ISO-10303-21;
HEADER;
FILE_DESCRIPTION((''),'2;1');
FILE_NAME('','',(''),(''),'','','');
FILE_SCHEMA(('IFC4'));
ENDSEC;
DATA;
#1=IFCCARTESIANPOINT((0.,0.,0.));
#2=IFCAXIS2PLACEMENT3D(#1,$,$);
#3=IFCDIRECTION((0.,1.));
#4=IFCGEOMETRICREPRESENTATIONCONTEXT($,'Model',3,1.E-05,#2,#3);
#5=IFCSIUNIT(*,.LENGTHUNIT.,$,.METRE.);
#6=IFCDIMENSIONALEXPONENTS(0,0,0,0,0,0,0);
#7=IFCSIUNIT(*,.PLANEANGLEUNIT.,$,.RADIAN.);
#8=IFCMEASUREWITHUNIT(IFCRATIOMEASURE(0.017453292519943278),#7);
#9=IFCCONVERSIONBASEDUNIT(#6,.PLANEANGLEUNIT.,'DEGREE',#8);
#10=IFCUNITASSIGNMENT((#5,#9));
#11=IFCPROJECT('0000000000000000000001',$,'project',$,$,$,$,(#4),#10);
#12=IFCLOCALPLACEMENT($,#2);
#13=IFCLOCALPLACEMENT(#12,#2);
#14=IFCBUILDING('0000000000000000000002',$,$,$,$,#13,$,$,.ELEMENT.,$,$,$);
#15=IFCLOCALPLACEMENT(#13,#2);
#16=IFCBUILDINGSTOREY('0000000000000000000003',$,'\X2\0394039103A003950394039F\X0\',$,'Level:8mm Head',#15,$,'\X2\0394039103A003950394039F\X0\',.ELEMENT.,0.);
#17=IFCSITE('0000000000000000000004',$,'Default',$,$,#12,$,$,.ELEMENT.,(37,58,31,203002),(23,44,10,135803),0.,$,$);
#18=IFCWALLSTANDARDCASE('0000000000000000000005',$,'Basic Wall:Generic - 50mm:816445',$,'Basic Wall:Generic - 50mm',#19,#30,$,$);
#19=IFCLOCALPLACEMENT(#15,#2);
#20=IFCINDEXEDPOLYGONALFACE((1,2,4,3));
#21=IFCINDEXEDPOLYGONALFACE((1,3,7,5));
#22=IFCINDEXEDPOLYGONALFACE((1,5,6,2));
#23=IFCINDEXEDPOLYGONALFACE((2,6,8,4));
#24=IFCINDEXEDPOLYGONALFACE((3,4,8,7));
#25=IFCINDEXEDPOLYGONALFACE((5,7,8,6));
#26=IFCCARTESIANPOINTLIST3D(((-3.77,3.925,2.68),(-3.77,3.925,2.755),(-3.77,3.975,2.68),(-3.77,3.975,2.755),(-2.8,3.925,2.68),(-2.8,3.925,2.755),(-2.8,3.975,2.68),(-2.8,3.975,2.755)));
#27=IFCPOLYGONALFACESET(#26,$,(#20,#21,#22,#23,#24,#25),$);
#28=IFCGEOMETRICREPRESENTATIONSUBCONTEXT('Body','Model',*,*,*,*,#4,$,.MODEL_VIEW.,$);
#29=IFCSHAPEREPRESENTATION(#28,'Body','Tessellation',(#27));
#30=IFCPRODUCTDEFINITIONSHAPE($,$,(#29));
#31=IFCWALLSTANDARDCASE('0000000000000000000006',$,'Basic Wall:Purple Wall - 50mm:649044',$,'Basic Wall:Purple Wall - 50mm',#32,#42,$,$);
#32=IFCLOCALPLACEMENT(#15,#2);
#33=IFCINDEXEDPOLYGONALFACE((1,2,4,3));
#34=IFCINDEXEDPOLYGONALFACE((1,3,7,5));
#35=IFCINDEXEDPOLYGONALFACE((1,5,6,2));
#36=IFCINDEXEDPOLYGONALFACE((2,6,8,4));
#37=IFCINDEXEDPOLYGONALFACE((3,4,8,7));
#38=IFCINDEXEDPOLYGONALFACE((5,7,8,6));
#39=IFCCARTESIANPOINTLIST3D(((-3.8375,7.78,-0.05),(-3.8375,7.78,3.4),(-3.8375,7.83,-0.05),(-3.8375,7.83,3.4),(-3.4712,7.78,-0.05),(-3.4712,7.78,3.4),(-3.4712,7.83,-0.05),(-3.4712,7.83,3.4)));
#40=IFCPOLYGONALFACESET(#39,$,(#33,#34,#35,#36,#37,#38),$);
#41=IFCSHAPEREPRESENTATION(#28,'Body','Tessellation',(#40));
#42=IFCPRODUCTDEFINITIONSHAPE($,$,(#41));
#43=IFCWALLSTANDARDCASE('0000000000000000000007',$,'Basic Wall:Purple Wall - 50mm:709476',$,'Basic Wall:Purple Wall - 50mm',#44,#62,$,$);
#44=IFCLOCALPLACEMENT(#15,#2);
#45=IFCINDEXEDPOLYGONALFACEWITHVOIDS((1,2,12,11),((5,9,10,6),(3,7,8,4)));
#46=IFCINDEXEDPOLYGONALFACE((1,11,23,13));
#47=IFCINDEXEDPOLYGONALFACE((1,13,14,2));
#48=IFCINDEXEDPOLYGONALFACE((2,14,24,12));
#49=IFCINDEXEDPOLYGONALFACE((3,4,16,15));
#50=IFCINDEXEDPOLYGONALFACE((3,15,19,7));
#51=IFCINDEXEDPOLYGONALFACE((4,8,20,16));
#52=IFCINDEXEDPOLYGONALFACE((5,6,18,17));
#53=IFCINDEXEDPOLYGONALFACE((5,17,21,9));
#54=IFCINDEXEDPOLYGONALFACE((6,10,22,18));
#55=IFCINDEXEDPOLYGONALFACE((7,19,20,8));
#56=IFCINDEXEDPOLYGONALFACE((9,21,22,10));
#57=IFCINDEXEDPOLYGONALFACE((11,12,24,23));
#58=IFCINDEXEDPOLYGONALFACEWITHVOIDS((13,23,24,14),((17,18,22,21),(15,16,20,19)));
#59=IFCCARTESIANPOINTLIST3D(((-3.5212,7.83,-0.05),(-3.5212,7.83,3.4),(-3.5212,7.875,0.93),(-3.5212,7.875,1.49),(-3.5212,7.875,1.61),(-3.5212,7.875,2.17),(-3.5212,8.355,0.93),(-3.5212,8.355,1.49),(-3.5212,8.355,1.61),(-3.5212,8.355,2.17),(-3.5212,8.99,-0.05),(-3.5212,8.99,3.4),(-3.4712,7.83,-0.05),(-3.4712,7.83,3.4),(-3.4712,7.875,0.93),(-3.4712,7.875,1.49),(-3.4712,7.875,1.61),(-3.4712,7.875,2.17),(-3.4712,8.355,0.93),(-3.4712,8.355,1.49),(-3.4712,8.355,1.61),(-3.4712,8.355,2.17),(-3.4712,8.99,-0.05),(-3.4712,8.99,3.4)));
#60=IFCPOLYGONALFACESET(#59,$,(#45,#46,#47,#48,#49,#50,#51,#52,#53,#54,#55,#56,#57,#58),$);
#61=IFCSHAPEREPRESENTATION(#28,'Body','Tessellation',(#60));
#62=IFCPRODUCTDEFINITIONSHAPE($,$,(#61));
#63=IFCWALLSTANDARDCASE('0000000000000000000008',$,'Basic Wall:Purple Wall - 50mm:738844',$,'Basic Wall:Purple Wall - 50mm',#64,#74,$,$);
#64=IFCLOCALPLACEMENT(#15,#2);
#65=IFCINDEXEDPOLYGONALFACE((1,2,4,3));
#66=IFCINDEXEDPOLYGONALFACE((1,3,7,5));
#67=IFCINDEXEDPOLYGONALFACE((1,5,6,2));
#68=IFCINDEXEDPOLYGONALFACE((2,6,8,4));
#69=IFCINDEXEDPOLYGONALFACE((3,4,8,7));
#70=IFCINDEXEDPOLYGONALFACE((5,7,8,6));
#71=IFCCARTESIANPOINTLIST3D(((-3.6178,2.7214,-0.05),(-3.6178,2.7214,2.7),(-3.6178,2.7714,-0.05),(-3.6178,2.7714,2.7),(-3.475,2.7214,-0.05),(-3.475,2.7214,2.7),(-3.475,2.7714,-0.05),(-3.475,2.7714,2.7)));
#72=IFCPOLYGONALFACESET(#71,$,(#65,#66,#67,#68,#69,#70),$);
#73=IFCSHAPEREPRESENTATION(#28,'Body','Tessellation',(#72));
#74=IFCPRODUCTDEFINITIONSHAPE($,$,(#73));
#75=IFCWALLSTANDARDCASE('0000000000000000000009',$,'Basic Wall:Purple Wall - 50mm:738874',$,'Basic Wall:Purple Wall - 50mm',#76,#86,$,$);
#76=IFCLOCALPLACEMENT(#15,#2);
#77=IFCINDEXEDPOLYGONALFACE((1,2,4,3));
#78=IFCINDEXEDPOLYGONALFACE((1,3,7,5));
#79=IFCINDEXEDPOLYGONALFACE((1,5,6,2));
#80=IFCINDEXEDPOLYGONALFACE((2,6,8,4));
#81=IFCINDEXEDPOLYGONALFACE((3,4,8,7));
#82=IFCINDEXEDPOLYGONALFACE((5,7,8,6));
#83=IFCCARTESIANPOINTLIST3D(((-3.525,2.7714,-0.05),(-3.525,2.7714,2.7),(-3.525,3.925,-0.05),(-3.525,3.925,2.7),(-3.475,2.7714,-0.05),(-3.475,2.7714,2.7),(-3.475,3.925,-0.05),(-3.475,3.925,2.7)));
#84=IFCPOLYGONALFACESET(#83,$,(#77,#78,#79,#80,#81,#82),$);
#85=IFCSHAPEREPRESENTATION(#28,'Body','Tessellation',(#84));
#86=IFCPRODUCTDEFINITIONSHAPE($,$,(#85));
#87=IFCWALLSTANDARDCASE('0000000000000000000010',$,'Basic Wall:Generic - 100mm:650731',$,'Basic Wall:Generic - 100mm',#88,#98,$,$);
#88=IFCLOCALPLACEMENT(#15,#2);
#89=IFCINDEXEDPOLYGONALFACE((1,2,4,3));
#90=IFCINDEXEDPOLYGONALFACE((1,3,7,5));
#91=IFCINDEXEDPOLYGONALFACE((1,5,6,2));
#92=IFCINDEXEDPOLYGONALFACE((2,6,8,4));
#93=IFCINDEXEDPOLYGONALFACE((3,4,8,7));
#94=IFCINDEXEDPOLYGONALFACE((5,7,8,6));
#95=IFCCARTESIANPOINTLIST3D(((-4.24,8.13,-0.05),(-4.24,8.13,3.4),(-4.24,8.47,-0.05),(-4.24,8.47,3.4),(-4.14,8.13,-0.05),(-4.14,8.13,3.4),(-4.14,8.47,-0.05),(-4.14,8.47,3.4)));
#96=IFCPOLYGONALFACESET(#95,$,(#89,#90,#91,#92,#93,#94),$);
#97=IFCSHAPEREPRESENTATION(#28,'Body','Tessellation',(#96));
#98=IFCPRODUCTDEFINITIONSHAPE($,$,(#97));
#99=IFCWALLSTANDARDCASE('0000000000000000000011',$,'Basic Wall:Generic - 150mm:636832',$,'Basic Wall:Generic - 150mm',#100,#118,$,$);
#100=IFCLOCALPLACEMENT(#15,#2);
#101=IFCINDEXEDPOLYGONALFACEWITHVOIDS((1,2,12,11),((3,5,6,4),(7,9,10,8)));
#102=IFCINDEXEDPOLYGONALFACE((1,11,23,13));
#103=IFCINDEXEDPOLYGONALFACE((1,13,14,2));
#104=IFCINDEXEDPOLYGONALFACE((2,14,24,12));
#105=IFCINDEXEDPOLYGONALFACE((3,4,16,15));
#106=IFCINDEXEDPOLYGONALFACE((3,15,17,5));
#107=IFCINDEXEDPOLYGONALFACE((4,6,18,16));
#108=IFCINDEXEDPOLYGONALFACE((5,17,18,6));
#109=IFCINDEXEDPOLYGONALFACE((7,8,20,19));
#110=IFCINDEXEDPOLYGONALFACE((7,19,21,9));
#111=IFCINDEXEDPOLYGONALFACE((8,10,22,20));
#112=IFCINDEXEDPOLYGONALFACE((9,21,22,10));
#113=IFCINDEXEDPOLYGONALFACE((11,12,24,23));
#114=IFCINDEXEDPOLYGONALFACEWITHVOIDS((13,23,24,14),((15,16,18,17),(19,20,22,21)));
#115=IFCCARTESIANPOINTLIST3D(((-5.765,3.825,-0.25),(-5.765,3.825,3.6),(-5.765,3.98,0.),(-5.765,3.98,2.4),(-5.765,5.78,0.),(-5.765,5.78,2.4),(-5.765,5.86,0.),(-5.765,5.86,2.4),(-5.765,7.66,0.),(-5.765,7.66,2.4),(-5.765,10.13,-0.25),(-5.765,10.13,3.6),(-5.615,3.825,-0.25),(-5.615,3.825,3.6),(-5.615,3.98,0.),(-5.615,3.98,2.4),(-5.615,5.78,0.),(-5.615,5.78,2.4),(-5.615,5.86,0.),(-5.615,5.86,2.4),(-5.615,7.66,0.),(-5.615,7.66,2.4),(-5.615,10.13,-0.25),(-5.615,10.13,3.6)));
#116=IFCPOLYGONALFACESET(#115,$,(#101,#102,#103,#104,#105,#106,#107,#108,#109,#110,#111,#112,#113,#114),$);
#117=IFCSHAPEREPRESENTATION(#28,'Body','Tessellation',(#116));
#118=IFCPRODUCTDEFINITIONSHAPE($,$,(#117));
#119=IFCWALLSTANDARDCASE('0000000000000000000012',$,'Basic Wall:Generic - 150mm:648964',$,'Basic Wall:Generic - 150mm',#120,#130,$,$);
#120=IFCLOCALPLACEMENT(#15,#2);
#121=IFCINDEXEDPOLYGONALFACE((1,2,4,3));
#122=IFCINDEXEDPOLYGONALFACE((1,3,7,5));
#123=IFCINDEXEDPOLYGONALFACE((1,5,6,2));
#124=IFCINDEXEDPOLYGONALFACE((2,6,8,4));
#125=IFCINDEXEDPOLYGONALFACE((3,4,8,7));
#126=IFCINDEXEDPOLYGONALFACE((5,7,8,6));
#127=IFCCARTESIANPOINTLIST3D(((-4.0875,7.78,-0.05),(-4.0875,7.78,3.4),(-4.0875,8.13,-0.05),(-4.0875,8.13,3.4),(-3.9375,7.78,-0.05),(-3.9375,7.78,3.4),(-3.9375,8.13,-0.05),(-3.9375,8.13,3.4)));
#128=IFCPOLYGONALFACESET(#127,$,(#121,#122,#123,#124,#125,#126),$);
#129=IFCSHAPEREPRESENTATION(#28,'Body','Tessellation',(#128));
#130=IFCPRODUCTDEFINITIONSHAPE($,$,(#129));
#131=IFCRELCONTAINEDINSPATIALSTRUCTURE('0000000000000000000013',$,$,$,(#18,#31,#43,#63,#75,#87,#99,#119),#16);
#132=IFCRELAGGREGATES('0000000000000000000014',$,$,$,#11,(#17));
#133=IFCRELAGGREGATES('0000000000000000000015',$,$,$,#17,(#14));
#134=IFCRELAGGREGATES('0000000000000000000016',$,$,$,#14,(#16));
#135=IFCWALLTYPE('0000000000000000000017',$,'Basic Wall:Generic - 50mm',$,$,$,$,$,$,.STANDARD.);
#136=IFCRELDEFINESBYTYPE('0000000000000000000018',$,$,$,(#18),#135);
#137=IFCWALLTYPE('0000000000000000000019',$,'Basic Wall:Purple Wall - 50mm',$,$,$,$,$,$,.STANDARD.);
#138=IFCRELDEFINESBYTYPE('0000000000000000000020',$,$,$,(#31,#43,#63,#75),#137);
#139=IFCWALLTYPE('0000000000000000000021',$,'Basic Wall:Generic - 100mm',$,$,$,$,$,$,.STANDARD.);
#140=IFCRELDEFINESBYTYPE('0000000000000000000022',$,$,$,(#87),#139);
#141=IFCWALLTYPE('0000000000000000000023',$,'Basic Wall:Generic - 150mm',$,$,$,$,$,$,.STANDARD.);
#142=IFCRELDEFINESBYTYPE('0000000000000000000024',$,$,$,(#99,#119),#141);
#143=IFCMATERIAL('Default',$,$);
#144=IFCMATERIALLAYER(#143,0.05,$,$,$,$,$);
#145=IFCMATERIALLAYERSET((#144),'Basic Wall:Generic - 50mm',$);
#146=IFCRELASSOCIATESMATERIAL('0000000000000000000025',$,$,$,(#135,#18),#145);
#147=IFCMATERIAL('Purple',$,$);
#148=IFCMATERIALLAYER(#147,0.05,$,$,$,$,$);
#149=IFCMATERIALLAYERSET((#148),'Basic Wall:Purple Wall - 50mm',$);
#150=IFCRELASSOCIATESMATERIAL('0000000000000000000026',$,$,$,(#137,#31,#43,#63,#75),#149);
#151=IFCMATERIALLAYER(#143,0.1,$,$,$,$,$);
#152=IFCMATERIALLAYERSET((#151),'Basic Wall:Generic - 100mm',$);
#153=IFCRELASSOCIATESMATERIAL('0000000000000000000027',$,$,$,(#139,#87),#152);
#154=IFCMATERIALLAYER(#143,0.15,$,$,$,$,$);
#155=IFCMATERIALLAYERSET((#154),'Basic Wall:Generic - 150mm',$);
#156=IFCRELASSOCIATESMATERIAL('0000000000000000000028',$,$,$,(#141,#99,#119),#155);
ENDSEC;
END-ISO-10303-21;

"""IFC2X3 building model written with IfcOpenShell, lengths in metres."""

from ifc_helpers import new_model, entity, si_unit, converted_unit, direction, frame, frame_2d, origin, place, context, subcontext, project, spatial, polyline, rectangle, extrude, clip, bounded_halfspace, material, layer, layer_set, layer_usage, type_object, element, save


model = new_model("IFC2X3")

# Units and contexts
model_context = context("Model", 3, precision=1e-05, world=origin(), true_north=direction((0.0, 1.0)))
body_context = subcontext(model_context, "Body", "Model", "MODEL_VIEW")
ifc_project = project(units=[si_unit("LENGTHUNIT", "METRE"), converted_unit("PLANEANGLEUNIT", "DEGREE", entity("IfcRatioMeasure", 0.017453292519943278), si_unit("PLANEANGLEUNIT", "RADIAN"), dimensions=[0, 0, 0, 0, 0, 0, 0])], contexts=[model_context])

# Site, building, storey
site_placement = place(None, origin())
site = spatial("IfcSite", under=ifc_project, at=site_placement, Name="Default", CompositionType="ELEMENT", RefLatitude=(37, 58, 31, 203002), RefLongitude=(23, 44, 10, 135803), RefElevation=0.0)
building_placement = place(site_placement, origin())
building = spatial("IfcBuilding", under=site, at=building_placement, CompositionType="ELEMENT")
storey_placement = place(building_placement, origin())
storey = spatial("IfcBuildingStorey", under=building, at=storey_placement, Name="ΔΑΠΕΔΟ", ObjectType="Level:8mm Head", LongName="ΔΑΠΕΔΟ", CompositionType="ELEMENT", Elevation=0.0)

# Walls
ifc_material_1 = material(Name="Default")
ifc_layer_1 = layer(ifc_material_1, 0.05)
ifc_layer_set_1 = layer_set([ifc_layer_1], Name="Basic Wall:Generic - 50mm")
wall_type_1 = type_object("IfcWallType", Name="Basic Wall:Generic - 50mm", PredefinedType="STANDARD", material=ifc_layer_set_1)
ifc_layer_usage_1 = layer_usage(ifc_layer_set_1, "AXIS2", "POSITIVE", -0.025)
wall_1_placement = place(storey_placement, frame((-2.8, 3.95, 2.68), z_axis=(0.0, 0.0, 1.0), x_axis=(-1.0, 0.0, 0.0)))
element("IfcWallStandardCase", 1, at=wall_1_placement, inside=storey, type_object=wall_type_1, material=ifc_layer_usage_1, Name="Basic Wall:Generic - 50mm:816445", ObjectType="Basic Wall:Generic - 50mm", context=body_context, shape_type="Clipping", body=[
    clip(extrude(rectangle(XDim=0.97, YDim=0.05, at=frame_2d((0.485, 0.0), x_axis=(-1.0, 0.0))), origin(), (0.0, 0.0, 1.0), 0.075), bounded_halfspace(frame((0.97, -0.025, 0.0), z_axis=(0.0, 0.0, 1.0), x_axis=(0.0, 1.0, 0.0)), True, frame((0.97, -0.025, 0.0), z_axis=(0.0, 0.0, 1.0), x_axis=(0.0, 1.0, 0.0)), polyline([(0.0, 0.0), (0.05, 0.0), (0.05, 0.97), (0.0, 0.97), (0.0, 0.0)]))),
])
ifc_material_2 = material(Name="Purple")
ifc_layer_2 = layer(ifc_material_2, 0.05)
ifc_layer_set_2 = layer_set([ifc_layer_2], Name="Basic Wall:Purple Wall - 50mm")
ifc_layer_usage_2 = layer_usage(ifc_layer_set_2, "AXIS2", "NEGATIVE", 0.025)
wall_type_2 = type_object("IfcWallType", Name="Basic Wall:Purple Wall - 50mm", PredefinedType="STANDARD", material=ifc_layer_set_2)
wall_2_placement = place(storey_placement, frame((-3.4712, 7.805, -0.05), z_axis=(0.0, 0.0, 1.0), x_axis=(-1.0, 0.0, 0.0)))
element("IfcWallStandardCase", 2, at=wall_2_placement, inside=storey, type_object=wall_type_2, material=ifc_layer_usage_2, Name="Basic Wall:Purple Wall - 50mm:649044", ObjectType="Basic Wall:Purple Wall - 50mm", context=body_context, shape_type="Clipping", body=[
    clip(clip(extrude(rectangle(XDim=0.3662, YDim=0.05, at=frame_2d((0.1831, 0.0), x_axis=(-1.0, 0.0))), origin(), (0.0, 0.0, 1.0), 3.45), bounded_halfspace(frame((0.0, -0.025, 3.45), z_axis=(0.0, 0.0, -1.0), x_axis=(0.0, 1.0, 0.0)), True, frame((0.0, -0.025, 3.45), z_axis=(0.0, 0.0, -1.0), x_axis=(0.0, 1.0, 0.0)), polyline([(0.0, 0.0), (0.05, 0.0), (0.05, 0.3662), (0.0, 0.3662), (0.0, 0.05), (0.0, 0.0)]))), bounded_halfspace(frame((0.3662, -0.025, 0.0), z_axis=(0.0, 0.0, 1.0), x_axis=(0.0, -1.0, 0.0)), True, frame((0.3662, -0.025, 0.0), z_axis=(0.0, 0.0, 1.0), x_axis=(0.0, -1.0, 0.0)), polyline([(0.0, 0.0), (-0.05, 0.0), (-0.05, -0.0062), (-0.05, -0.3662), (0.0, -0.3662), (0.0, -0.3162), (0.0, 0.0)]))),
])

# Wall, openings
ifc_layer_usage_3 = layer_usage(ifc_layer_set_2, "AXIS2", "POSITIVE", -0.025)
wall_3_placement = place(storey_placement, frame((-3.4962, 7.83, -0.05), z_axis=(0.0, 0.0, 1.0), x_axis=(0.0, 1.0, 0.0)))
wall_3 = element("IfcWallStandardCase", 3, at=wall_3_placement, inside=storey, type_object=wall_type_2, material=ifc_layer_usage_3, Name="Basic Wall:Purple Wall - 50mm:709476", ObjectType="Basic Wall:Purple Wall - 50mm", context=body_context, shape_type="Clipping", body=[
    clip(clip(extrude(rectangle(XDim=1.16, YDim=0.05, at=frame_2d((0.58, 0.0), x_axis=(-1.0, 0.0))), origin(), (0.0, 0.0, 1.0), 3.45), bounded_halfspace(frame((0.0, -0.025, 3.45), z_axis=(0.0, 0.0, -1.0), x_axis=(-1.0, 0.0, 0.0)), True, frame((0.0, -0.025, 3.45), z_axis=(0.0, 0.0, -1.0), x_axis=(-1.0, 0.0, 0.0)), polyline([(0.0, 0.0), (0.0, 0.05), (-1.11, 0.05), (-1.16, 0.05), (-1.16, 0.0), (0.0, 0.0)]))), bounded_halfspace(frame((1.16, -0.025, 0.0)), True, frame((1.16, -0.025, 0.0)), polyline([(0.0, 0.0), (0.0, 0.05), (-0.05, 0.05), (-1.16, 0.05), (-1.16, 0.0), (0.0, 0.0)]))),
])
opening_1_placement = place(wall_3_placement, origin())
element("IfcOpeningElement", 4, at=opening_1_placement, cuts=wall_3, ObjectType="Opening", context=body_context, shape_type="SweptSolid", body=[
    extrude(rectangle(XDim=0.56, YDim=0.48, at=frame_2d((0.0, 0.0), x_axis=(0.0, 1.0))), frame((0.285, -0.1231, 1.26), z_axis=(0.0, 1.0, 0.0), x_axis=(1.0, 0.0, 0.0)), (0.0, 0.0, 1.0), 0.33),
])
opening_2_placement = place(wall_3_placement, origin())
element("IfcOpeningElement", 5, at=opening_2_placement, cuts=wall_3, ObjectType="Opening", context=body_context, shape_type="SweptSolid", body=[
    extrude(rectangle(XDim=0.56, YDim=0.48, at=frame_2d((0.0, 0.0), x_axis=(0.0, 1.0))), frame((0.285, -0.1231, 1.94), z_axis=(0.0, 1.0, 0.0), x_axis=(1.0, 0.0, 0.0)), (0.0, 0.0, 1.0), 0.33),
])

# Walls
wall_4_placement = place(storey_placement, frame((-3.6178, 2.7464, -0.05)))
element("IfcWallStandardCase", 6, at=wall_4_placement, inside=storey, type_object=wall_type_2, material=ifc_layer_usage_3, Name="Basic Wall:Purple Wall - 50mm:738844", ObjectType="Basic Wall:Purple Wall - 50mm", context=body_context, shape_type="Clipping", body=[
    clip(clip(extrude(rectangle(XDim=0.1428, YDim=0.05, at=frame_2d((0.0714, 0.0), x_axis=(-1.0, 0.0))), origin(), (0.0, 0.0, 1.0), 2.75), bounded_halfspace(frame((0.0, -0.025, 2.75), z_axis=(0.0, 0.0, -1.0), x_axis=(1.0, 0.0, 0.0)), True, frame((0.0, -0.025, 2.75)), polyline([(0.0, 0.0), (0.1428, 0.0), (0.1428, 0.05), (0.0928, 0.05), (0.0, 0.05), (0.0, 0.0)]))), bounded_halfspace(frame((0.1428, -0.025, 0.0), z_axis=(0.0, 0.0, 1.0), x_axis=(0.0, 1.0, 0.0)), True, frame((0.1428, -0.025, 0.0), z_axis=(0.0, 0.0, 1.0), x_axis=(0.0, 1.0, 0.0)), polyline([(0.0, 0.0), (0.05, 0.0), (0.05, 0.05), (0.05, 0.1428), (0.0, 0.1428), (0.0, 0.0)]))),
])
wall_5_placement = place(storey_placement, frame((-3.5, 2.7714, -0.05), z_axis=(0.0, 0.0, 1.0), x_axis=(0.0, 1.0, 0.0)))
element("IfcWallStandardCase", 7, at=wall_5_placement, inside=storey, type_object=wall_type_2, material=ifc_layer_usage_3, Name="Basic Wall:Purple Wall - 50mm:738874", ObjectType="Basic Wall:Purple Wall - 50mm", context=body_context, shape_type="Clipping", body=[
    clip(clip(extrude(rectangle(XDim=1.1536, YDim=0.05, at=frame_2d((0.5768, 0.0), x_axis=(-1.0, 0.0))), origin(), (0.0, 0.0, 1.0), 2.75), bounded_halfspace(frame((0.0, -0.025, 2.75), z_axis=(0.0, 0.0, -1.0), x_axis=(0.0, -1.0, 0.0)), True, frame((0.0, -0.025, 2.75)), polyline([(0.0, 0.0), (1.1536, 0.0), (1.1536, 0.05), (1.0536, 0.05), (0.0, 0.05), (0.0, 0.0)]))), bounded_halfspace(frame((1.1536, -0.025, 0.0)), True, frame((1.1536, -0.025, 0.0)), polyline([(0.0, 0.0), (0.0, 0.05), (-0.1, 0.05), (-1.1536, 0.05), (-1.1536, 0.0), (0.0, 0.0)]))),
])

# Wall, opening
ifc_layer_3 = layer(ifc_material_1, 0.1)
ifc_layer_set_3 = layer_set([ifc_layer_3], Name="Basic Wall:Generic - 100mm")
ifc_layer_usage_4 = layer_usage(ifc_layer_set_3, "AXIS2", "NEGATIVE", 0.05)
wall_type_3 = type_object("IfcWallType", Name="Basic Wall:Generic - 100mm", PredefinedType="STANDARD", material=ifc_layer_set_3)
wall_6_placement = place(storey_placement, frame((-4.19, 8.13, -0.05), z_axis=(0.0, 0.0, 1.0), x_axis=(0.0, 1.0, 0.0)))
wall_6 = element("IfcWallStandardCase", 8, at=wall_6_placement, inside=storey, type_object=wall_type_3, material=ifc_layer_usage_4, Name="Basic Wall:Generic - 100mm:650731", ObjectType="Basic Wall:Generic - 100mm", context=body_context, shape_type="Clipping", body=[
    clip(clip(extrude(rectangle(XDim=0.34, YDim=0.1, at=frame_2d((0.17, 0.0), x_axis=(-1.0, 0.0))), origin(), (0.0, 0.0, 1.0), 3.45), bounded_halfspace(frame((0.0, -0.05, 3.45), z_axis=(0.0, 0.0, -1.0), x_axis=(-1.0, 0.0, 0.0)), True, frame((0.0, -0.05, 3.45), z_axis=(0.0, 0.0, -1.0), x_axis=(-1.0, 0.0, 0.0)), polyline([(0.0, 0.0), (0.0, 0.1), (-0.24, 0.1), (-0.34, 0.1), (-0.34, 0.0), (-0.15, 0.0), (0.0, 0.0)]))), bounded_halfspace(frame((0.34, -0.05, 0.0)), True, frame((0.34, -0.05, 0.0)), polyline([(0.0, 0.0), (0.0, 0.1), (-0.1, 0.1), (-0.34, 0.1), (-0.34, 0.0), (-0.19, 0.0), (0.0, 0.0)]))),
])
opening_3_placement = place(wall_6_placement, origin())
element("IfcOpeningElement", 9, at=opening_3_placement, cuts=wall_6, ObjectType="Opening", context=body_context, shape_type="SweptSolid", body=[
    extrude(rectangle(XDim=1.9, YDim=0.1, at=frame_2d((0.0, 0.0), x_axis=(0.0, 1.0))), frame((0.29, 0.05, 1.0), z_axis=(0.0, 1.0, 0.0), x_axis=(1.0, 0.0, 0.0)), (0.0, 0.0, 1.0), 0.8),
])

# Wall, openings
ifc_layer_4 = layer(ifc_material_1, 0.15)
ifc_layer_set_4 = layer_set([ifc_layer_4], Name="Basic Wall:Generic - 150mm")
ifc_layer_usage_5 = layer_usage(ifc_layer_set_4, "AXIS2", "NEGATIVE", 0.075)
wall_type_4 = type_object("IfcWallType", Name="Basic Wall:Generic - 150mm", PredefinedType="STANDARD", material=ifc_layer_set_4)
wall_7_placement = place(storey_placement, frame((-5.69, 3.825, -0.25), z_axis=(0.0, 0.0, 1.0), x_axis=(0.0, 1.0, 0.0)))
wall_7 = element("IfcWallStandardCase", 10, at=wall_7_placement, inside=storey, type_object=wall_type_4, material=ifc_layer_usage_5, Name="Basic Wall:Generic - 150mm:636832", ObjectType="Basic Wall:Generic - 150mm", context=body_context, shape_type="SweptSolid", body=[
    extrude(rectangle(XDim=6.305, YDim=0.15, at=frame_2d((3.1525, 0.0), x_axis=(-1.0, 0.0))), origin(), (0.0, 0.0, 1.0), 3.85),
])
opening_4_placement = place(wall_7_placement, frame((2.035, -0.075, 0.25)))
element("IfcOpeningElement", 11, at=opening_4_placement, cuts=wall_7, ObjectType="Opening", context=body_context, shape_type="SweptSolid", body=[
    extrude(rectangle(XDim=2.4, YDim=1.8, at=frame_2d((1.2, 0.9), x_axis=(-1.0, 0.0))), frame((0.0, 0.0, 0.0), z_axis=(0.0, 1.0, 0.0), x_axis=(0.0, 0.0, 1.0)), (0.0, 0.0, 1.0), 0.15),
])
opening_5_placement = place(wall_7_placement, frame((1.955, 0.075, 0.25)))
element("IfcOpeningElement", 12, at=opening_5_placement, cuts=wall_7, ObjectType="Opening", context=body_context, shape_type="SweptSolid", body=[
    extrude(rectangle(XDim=2.4, YDim=1.8, at=frame_2d((1.2, 0.9), x_axis=(-1.0, 0.0))), frame((0.0, 0.0, 0.0), z_axis=(0.0, -1.0, 0.0), x_axis=(0.0, 0.0, 1.0)), (0.0, 0.0, 1.0), 0.15),
])

# Wall
ifc_layer_usage_6 = layer_usage(ifc_layer_set_4, "AXIS2", "POSITIVE", -0.075)
wall_8_placement = place(storey_placement, frame((-4.0125, 8.13, -0.05), z_axis=(0.0, 0.0, 1.0), x_axis=(0.0, -1.0, 0.0)))
element("IfcWallStandardCase", 13, at=wall_8_placement, inside=storey, type_object=wall_type_4, material=ifc_layer_usage_6, Name="Basic Wall:Generic - 150mm:648964", ObjectType="Basic Wall:Generic - 150mm", context=body_context, shape_type="Clipping", body=[
    clip(clip(extrude(rectangle(XDim=0.35, YDim=0.15, at=frame_2d((0.175, 0.0), x_axis=(-1.0, 0.0))), origin(), (0.0, 0.0, 1.0), 3.45), bounded_halfspace(frame((0.0, -0.075, 3.45), z_axis=(0.0, 0.0, -1.0), x_axis=(1.0, 0.0, 0.0)), True, frame((0.0, -0.075, 3.45), z_axis=(0.0, 0.0, -1.0), x_axis=(1.0, 0.0, 0.0)), polyline([(0.0, 0.0), (0.0, -0.15), (0.35, -0.15), (0.35, 0.0), (0.0, 0.0)]))), bounded_halfspace(frame((0.35, -0.075, 0.0), z_axis=(0.0, 0.0, 1.0), x_axis=(-1.0, 0.0, 0.0)), True, frame((0.35, -0.075, 0.0), z_axis=(0.0, 0.0, 1.0), x_axis=(-1.0, 0.0, 0.0)), polyline([(0.0, 0.0), (0.0, -0.15), (0.35, -0.15), (0.35, 0.0), (0.0, 0.0)]))),
])

save(model, "model.ifc")
